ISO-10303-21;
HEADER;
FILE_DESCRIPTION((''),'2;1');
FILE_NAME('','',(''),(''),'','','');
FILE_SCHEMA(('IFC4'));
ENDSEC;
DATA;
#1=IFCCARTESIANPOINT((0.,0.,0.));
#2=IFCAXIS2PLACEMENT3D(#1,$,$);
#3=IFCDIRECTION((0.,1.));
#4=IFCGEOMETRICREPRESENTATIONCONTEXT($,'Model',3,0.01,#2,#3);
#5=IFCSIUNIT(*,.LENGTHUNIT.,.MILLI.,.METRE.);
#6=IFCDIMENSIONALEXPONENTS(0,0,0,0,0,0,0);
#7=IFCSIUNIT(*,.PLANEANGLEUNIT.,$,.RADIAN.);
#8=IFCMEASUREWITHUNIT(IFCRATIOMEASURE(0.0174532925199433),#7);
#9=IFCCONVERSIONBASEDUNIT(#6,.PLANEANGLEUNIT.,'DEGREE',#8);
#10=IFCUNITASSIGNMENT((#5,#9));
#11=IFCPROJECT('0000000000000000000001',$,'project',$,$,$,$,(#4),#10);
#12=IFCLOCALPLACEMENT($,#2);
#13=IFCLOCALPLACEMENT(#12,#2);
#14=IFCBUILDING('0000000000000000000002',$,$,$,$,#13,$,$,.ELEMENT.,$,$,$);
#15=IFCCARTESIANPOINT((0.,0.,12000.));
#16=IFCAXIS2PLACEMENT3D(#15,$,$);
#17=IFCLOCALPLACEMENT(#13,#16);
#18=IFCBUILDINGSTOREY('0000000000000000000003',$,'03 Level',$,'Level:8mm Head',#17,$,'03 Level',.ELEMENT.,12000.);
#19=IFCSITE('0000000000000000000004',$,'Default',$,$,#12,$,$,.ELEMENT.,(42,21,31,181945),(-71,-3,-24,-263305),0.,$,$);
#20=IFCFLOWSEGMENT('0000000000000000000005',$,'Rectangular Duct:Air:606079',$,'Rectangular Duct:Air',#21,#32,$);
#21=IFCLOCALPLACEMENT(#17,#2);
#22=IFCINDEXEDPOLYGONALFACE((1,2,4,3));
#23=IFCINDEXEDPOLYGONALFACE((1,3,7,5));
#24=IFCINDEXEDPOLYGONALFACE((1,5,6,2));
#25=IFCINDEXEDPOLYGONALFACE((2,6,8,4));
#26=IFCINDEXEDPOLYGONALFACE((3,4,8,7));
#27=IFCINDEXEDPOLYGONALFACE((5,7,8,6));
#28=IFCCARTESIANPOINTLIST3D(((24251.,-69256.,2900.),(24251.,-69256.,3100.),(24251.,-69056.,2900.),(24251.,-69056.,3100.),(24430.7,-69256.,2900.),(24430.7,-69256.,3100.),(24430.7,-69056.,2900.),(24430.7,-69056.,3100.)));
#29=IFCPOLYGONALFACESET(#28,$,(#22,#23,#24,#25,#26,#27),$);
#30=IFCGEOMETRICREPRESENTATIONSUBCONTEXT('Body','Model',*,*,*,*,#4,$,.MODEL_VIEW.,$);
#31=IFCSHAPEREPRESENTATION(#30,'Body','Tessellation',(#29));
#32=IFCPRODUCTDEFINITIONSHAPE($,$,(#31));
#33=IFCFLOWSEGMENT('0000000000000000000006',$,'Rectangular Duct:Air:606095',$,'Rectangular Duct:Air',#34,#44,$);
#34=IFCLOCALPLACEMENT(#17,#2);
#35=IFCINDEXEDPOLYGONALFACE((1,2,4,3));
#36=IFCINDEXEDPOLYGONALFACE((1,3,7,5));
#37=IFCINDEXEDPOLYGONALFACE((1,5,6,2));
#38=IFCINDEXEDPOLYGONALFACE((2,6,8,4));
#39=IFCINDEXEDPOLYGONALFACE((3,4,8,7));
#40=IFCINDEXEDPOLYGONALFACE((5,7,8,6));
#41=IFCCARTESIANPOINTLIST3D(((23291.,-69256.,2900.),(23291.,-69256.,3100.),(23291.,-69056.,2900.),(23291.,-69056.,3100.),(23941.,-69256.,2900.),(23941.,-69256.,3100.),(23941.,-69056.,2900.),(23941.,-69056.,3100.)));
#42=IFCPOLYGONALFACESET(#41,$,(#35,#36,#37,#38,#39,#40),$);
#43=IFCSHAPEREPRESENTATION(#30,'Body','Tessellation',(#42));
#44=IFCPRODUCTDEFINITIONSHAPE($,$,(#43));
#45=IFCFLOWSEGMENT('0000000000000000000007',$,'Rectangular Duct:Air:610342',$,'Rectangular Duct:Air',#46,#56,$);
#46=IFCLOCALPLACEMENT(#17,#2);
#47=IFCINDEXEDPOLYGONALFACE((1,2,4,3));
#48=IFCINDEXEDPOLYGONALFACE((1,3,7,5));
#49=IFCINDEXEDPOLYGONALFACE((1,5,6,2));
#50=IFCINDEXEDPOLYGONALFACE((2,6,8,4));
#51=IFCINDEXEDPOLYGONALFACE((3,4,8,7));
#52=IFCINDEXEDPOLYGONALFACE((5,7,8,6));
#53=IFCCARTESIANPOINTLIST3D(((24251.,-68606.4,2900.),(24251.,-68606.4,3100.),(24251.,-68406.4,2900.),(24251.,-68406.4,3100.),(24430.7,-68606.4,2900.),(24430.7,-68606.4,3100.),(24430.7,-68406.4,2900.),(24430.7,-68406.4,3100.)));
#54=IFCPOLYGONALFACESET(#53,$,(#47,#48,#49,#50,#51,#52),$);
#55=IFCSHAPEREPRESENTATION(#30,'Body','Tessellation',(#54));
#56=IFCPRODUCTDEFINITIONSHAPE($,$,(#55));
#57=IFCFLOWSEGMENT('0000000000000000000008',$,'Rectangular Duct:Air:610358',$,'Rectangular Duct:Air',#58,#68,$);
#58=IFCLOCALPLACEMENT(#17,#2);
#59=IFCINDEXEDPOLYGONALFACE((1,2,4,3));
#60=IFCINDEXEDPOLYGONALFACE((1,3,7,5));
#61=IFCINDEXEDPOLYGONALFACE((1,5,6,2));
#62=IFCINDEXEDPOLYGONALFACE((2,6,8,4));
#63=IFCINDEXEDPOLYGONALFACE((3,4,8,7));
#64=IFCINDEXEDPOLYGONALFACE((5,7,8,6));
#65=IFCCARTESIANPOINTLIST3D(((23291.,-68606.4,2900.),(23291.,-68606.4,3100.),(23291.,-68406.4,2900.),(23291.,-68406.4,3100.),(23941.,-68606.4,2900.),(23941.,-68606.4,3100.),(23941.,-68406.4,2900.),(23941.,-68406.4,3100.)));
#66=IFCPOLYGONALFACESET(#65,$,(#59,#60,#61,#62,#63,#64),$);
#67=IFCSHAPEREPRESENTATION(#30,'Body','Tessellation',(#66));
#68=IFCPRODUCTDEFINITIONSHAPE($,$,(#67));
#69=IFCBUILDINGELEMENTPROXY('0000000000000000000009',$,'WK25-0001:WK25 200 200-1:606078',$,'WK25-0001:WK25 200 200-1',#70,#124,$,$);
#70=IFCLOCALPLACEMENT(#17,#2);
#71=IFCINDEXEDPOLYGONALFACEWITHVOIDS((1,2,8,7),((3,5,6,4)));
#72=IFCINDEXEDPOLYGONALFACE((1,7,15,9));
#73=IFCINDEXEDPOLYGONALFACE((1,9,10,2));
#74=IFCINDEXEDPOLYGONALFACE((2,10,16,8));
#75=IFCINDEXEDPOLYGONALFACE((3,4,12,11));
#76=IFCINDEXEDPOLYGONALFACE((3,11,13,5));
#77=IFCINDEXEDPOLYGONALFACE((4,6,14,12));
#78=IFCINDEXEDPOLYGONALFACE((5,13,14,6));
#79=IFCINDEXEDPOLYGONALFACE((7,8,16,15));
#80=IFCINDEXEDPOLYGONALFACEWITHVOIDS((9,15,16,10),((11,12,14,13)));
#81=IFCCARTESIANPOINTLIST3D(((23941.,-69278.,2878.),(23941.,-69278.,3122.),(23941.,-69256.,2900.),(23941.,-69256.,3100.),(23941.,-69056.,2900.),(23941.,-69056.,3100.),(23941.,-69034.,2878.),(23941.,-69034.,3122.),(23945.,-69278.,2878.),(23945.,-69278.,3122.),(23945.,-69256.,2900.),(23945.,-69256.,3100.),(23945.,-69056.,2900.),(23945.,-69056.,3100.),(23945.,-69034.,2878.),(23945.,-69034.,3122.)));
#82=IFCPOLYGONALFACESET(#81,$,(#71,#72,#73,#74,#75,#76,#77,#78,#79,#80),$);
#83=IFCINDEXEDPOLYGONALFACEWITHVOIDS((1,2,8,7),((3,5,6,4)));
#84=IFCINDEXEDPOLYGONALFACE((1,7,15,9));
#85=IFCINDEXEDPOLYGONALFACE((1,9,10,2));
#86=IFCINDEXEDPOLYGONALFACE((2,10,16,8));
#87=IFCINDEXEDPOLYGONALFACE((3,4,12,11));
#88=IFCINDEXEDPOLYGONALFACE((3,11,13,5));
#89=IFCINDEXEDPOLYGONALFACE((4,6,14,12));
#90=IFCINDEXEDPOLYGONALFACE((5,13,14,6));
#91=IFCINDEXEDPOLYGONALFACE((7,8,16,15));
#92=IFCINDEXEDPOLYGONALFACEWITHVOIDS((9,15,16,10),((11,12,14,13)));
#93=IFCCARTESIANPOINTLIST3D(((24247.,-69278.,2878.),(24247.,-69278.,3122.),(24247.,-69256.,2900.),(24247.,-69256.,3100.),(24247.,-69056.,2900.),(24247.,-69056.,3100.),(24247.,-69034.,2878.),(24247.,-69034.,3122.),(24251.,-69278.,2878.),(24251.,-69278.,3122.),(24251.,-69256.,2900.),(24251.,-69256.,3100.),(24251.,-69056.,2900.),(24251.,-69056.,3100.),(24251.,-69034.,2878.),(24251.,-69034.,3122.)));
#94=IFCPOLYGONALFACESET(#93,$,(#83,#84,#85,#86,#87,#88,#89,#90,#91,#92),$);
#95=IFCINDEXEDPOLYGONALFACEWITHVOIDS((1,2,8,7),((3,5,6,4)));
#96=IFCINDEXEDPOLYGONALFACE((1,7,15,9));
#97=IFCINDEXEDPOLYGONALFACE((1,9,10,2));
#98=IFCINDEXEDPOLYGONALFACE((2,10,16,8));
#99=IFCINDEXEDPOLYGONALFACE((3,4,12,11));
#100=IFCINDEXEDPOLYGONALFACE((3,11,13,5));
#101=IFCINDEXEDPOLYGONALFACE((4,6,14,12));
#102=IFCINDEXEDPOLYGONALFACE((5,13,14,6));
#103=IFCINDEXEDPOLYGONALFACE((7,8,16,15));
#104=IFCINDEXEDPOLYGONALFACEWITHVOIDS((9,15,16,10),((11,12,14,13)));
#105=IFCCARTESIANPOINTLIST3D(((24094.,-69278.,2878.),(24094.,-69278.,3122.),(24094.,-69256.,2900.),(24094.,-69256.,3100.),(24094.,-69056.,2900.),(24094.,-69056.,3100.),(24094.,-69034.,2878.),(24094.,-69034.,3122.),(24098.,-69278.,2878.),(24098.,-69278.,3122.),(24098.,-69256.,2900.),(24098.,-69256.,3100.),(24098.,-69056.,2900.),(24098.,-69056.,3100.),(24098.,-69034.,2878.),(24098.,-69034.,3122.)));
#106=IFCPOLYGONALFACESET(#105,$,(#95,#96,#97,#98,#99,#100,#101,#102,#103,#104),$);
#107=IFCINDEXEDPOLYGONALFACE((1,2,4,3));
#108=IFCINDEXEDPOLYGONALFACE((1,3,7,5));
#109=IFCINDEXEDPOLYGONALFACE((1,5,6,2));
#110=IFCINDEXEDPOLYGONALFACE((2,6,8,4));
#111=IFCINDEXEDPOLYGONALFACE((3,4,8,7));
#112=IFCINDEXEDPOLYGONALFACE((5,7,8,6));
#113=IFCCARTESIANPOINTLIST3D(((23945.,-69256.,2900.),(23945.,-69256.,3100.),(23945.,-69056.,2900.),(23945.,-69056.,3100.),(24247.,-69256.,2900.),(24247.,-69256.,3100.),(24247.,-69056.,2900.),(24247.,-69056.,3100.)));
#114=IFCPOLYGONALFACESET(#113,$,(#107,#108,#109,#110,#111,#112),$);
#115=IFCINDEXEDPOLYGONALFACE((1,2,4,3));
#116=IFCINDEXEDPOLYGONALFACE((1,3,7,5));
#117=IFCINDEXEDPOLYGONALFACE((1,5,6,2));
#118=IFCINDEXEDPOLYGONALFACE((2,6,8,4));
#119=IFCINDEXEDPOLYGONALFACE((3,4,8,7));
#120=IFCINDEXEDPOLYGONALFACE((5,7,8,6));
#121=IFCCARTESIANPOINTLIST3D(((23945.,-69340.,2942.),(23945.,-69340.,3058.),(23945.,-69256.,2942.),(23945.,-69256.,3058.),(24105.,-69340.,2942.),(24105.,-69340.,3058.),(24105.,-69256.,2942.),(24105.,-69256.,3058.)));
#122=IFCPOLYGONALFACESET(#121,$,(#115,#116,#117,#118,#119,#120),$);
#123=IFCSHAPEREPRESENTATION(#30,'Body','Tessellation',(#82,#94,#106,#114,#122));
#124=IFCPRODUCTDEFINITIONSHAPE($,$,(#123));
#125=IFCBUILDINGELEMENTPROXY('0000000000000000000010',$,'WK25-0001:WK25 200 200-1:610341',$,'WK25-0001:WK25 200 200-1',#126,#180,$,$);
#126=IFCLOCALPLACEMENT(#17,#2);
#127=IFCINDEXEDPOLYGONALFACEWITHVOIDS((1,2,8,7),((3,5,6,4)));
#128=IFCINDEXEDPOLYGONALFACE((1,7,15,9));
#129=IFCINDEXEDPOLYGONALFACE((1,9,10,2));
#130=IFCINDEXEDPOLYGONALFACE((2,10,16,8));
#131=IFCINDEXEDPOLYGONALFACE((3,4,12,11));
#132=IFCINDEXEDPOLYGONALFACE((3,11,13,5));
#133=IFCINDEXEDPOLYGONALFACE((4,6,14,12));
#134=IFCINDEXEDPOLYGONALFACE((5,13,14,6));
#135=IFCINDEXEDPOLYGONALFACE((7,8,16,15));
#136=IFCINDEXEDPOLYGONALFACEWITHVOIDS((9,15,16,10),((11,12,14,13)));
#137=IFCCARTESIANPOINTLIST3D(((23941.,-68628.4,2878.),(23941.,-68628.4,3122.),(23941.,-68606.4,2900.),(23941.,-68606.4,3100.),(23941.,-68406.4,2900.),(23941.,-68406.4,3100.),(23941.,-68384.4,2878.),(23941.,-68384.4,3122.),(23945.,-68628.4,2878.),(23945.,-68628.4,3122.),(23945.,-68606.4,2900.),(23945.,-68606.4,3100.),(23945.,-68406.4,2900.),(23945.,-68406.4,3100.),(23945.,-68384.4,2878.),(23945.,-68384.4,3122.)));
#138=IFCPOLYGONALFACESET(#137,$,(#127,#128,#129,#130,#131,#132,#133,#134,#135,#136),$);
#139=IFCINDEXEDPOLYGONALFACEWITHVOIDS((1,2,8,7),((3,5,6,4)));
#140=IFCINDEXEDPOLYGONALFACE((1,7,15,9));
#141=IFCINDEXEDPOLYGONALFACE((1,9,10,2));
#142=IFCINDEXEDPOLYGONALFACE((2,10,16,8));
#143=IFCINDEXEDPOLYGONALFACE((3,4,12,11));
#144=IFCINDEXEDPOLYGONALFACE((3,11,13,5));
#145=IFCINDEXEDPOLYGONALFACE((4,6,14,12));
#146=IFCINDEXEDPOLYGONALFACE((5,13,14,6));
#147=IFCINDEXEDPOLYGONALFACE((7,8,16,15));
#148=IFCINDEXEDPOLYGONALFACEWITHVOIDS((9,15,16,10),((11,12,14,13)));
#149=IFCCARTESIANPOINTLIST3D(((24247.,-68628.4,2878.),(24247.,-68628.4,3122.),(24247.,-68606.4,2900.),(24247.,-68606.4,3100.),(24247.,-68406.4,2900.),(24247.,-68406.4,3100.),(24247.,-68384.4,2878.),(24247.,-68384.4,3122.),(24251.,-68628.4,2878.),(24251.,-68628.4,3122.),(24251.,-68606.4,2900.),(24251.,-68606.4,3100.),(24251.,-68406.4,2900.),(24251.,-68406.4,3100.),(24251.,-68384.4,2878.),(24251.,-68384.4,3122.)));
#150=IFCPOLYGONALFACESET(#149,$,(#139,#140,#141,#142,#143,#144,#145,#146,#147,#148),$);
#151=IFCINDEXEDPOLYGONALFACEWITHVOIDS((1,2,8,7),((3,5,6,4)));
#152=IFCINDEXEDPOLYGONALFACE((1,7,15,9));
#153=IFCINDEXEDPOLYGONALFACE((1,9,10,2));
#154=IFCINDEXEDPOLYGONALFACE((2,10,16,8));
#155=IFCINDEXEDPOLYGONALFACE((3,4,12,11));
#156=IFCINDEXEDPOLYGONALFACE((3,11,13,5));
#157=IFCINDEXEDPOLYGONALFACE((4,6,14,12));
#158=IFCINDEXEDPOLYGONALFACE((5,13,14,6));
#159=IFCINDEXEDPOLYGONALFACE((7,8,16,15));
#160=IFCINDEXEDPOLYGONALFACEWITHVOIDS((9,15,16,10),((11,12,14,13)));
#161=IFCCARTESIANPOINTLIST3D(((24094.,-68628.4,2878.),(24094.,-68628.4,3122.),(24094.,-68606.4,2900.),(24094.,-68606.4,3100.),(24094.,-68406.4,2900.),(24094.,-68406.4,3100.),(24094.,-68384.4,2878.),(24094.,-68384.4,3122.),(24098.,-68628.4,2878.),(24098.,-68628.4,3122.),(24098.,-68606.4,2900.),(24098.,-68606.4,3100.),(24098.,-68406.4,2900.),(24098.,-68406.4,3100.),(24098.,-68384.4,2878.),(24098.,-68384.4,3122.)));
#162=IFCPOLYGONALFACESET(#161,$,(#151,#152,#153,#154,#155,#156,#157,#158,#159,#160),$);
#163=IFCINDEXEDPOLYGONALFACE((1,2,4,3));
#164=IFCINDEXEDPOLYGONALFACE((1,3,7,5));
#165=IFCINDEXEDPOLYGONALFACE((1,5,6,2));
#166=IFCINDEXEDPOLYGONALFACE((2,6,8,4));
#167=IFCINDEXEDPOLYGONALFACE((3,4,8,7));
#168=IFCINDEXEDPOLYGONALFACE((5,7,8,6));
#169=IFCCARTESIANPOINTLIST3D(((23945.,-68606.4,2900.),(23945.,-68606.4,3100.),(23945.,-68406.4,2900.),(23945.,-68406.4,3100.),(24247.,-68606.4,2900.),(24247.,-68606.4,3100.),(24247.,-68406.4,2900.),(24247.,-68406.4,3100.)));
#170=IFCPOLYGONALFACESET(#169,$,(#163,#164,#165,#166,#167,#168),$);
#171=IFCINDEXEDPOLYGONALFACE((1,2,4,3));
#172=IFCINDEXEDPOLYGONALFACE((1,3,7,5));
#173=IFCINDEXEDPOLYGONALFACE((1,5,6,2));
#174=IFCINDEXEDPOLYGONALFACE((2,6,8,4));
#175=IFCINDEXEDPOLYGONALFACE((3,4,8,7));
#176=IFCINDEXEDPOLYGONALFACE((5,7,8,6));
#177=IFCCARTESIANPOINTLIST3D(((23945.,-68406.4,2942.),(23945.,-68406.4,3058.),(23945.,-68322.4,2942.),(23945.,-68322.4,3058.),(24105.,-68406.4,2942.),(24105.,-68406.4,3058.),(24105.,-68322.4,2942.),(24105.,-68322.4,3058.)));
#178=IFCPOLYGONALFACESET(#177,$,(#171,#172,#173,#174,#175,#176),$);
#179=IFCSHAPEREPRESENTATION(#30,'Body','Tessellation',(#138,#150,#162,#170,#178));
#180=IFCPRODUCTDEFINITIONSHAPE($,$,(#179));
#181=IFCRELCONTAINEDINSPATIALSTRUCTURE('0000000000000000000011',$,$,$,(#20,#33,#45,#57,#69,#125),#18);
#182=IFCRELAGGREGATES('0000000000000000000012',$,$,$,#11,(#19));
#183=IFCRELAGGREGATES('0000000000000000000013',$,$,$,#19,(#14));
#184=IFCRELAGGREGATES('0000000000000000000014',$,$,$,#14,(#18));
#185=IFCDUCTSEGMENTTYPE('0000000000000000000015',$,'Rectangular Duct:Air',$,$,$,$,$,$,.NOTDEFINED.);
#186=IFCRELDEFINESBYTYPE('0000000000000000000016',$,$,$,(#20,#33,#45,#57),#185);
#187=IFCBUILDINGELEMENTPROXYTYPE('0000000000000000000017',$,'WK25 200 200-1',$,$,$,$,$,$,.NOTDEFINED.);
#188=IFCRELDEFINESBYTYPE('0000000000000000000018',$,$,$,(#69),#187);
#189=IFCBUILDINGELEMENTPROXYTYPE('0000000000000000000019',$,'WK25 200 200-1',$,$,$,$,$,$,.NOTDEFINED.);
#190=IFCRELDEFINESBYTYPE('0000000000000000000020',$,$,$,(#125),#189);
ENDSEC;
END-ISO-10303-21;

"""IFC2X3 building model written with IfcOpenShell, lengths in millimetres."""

from ifc_helpers import new_model, entity, si_unit, converted_unit, direction, frame, frame_2d, origin, origin_2d_with_axis, place, context, subcontext, project, spatial, polyline, rectangle, outline, extrude, source, transform, mapped, type_object, type_shapes, element, save


model = new_model("IFC2X3")

# Units and contexts
model_context = context("Model", 3, precision=0.01, world=origin(), true_north=direction((0.0, 1.0)))
body_context = subcontext(model_context, "Body", "Model", "MODEL_VIEW")
ifc_project = project(units=[si_unit("LENGTHUNIT", "METRE", prefix="MILLI"), converted_unit("PLANEANGLEUNIT", "DEGREE", entity("IfcRatioMeasure", 0.0174532925199433), si_unit("PLANEANGLEUNIT", "RADIAN"), dimensions=[0, 0, 0, 0, 0, 0, 0])], contexts=[model_context])

# Site, building, storey
site_placement = place(None, origin())
site = spatial("IfcSite", under=ifc_project, at=site_placement, Name="Default", CompositionType="ELEMENT", RefLatitude=(42, 21, 31, 181945), RefLongitude=(-71, -3, -24, -263305), RefElevation=0.0)
building_placement = place(site_placement, origin())
building = spatial("IfcBuilding", under=site, at=building_placement, CompositionType="ELEMENT")
storey_placement = place(building_placement, frame((0.0, 0.0, 12000.0)))
storey = spatial("IfcBuildingStorey", under=building, at=storey_placement, Name="03 Level", ObjectType="Level:8mm Head", LongName="03 Level", CompositionType="ELEMENT", Elevation=12000.0)

# Flow segments
duct_segment_type_1 = type_object("IfcDuctSegmentType", Name="Rectangular Duct:Air", PredefinedType="NOTDEFINED")
flow_segment_1_placement = place(storey_placement, frame((24251.0, -69256.0, 2900.0)))
element("IfcFlowSegment", 1, at=flow_segment_1_placement, inside=storey, type_object=duct_segment_type_1, Name="Rectangular Duct:Air:606079", ObjectType="Rectangular Duct:Air", context=body_context, shape_type="SweptSolid", body=[
    extrude(rectangle(XDim=179.7, YDim=200.0, at=frame_2d((0.0, 0.0), x_axis=(1.0, 0.0))), frame((89.8, 100.0, 0.0)), (0.0, 0.0, 1.0), 200.0),
])
flow_segment_2_placement = place(storey_placement, frame((23291.0, -69256.0, 2900.0)))
element("IfcFlowSegment", 2, at=flow_segment_2_placement, inside=storey, type_object=duct_segment_type_1, Name="Rectangular Duct:Air:606095", ObjectType="Rectangular Duct:Air", context=body_context, shape_type="SweptSolid", body=[
    extrude(rectangle(XDim=650.0, YDim=200.0, at=frame_2d((0.0, 0.0), x_axis=(1.0, 0.0))), frame((325.0, 100.0, 0.0), z_axis=(0.0, 0.0, 1.0), x_axis=(-1.0, 0.0, 0.0)), (0.0, 0.0, 1.0), 200.0),
])
flow_segment_3_placement = place(storey_placement, frame((24251.0, -68606.4, 2900.0)))
element("IfcFlowSegment", 3, at=flow_segment_3_placement, inside=storey, type_object=duct_segment_type_1, Name="Rectangular Duct:Air:610342", ObjectType="Rectangular Duct:Air", context=body_context, shape_type="SweptSolid", body=[
    extrude(rectangle(XDim=179.7, YDim=200.0, at=frame_2d((0.0, 0.0), x_axis=(1.0, 0.0))), frame((89.8, 100.0, 0.0)), (0.0, 0.0, 1.0), 200.0),
])
flow_segment_4_placement = place(storey_placement, frame((23291.0, -68606.4, 2900.0)))
element("IfcFlowSegment", 4, at=flow_segment_4_placement, inside=storey, type_object=duct_segment_type_1, Name="Rectangular Duct:Air:610358", ObjectType="Rectangular Duct:Air", context=body_context, shape_type="SweptSolid", body=[
    extrude(rectangle(XDim=650.0, YDim=200.0, at=frame_2d((0.0, 0.0), x_axis=(1.0, 0.0))), frame((325.0, 100.0, 0.0), z_axis=(0.0, 0.0, 1.0), x_axis=(-1.0, 0.0, 0.0)), (0.0, 0.0, 1.0), 200.0),
])

# Building element proxies
building_element_proxy_type_1 = type_object("IfcBuildingElementProxyType", Name="WK25 200 200-1", PredefinedType="NOTDEFINED")
shared_shape_1 = source(origin(), body_context, "Body", "SweptSolid", [
    extrude(outline(polyline([(-122.0, -122.0), (122.0, -122.0), (122.0, 122.0), (-122.0, 122.0), (-122.0, -122.0)]), holes=[polyline([(-100.0, -100.0), (-100.0, 100.0), (100.0, 100.0), (100.0, -100.0), (-100.0, -100.0)])]), frame((151.0, 0.0, 0.0), z_axis=(1.0, 0.0, 0.0), x_axis=(0.0, 0.0, -1.0)), (0.0, 0.0, 1.0), 4.0),
    extrude(outline(polyline([(-122.0, -122.0), (122.0, -122.0), (122.0, 122.0), (-122.0, 122.0), (-122.0, -122.0)]), holes=[polyline([(-100.0, -100.0), (-100.0, 100.0), (100.0, 100.0), (100.0, -100.0), (-100.0, -100.0)])]), frame((-155.0, 0.0, 0.0), z_axis=(1.0, 0.0, 0.0), x_axis=(0.0, -1.0, 0.0)), (0.0, 0.0, 1.0), 4.0),
    extrude(outline(polyline([(-122.0, -122.0), (122.0, -122.0), (122.0, 122.0), (-122.0, 122.0), (-122.0, -122.0)]), holes=[polyline([(-100.0, -100.0), (-100.0, 100.0), (100.0, 100.0), (100.0, -100.0), (-100.0, -100.0)])]), frame((-2.0, 0.0, 0.0), z_axis=(1.0, 0.0, 0.0), x_axis=(0.0, -1.0, 0.0)), (0.0, 0.0, 1.0), 4.0),
    extrude(rectangle(XDim=302.0, YDim=200.0, at=origin_2d_with_axis()), frame((0.0, 0.0, -100.0), z_axis=(0.0, 0.0, 1.0), x_axis=(-1.0, 0.0, 0.0)), (0.0, 0.0, 1.0), 200.0),
    extrude(rectangle(XDim=84.0, YDim=160.0, at=frame_2d((0.0, 0.0), x_axis=(1.0, 0.0))), frame((71.0, -142.0, -58.0), z_axis=(0.0, 0.0, 1.0), x_axis=(0.0, -1.0, 0.0)), (0.0, 0.0, 1.0), 116.0),
])
type_shapes(building_element_proxy_type_1, [shared_shape_1])
proxy_1_placement = place(storey_placement, frame((24096.0, -69156.0, 3000.0), z_axis=(0.0, 0.0, -1.0), x_axis=(-1.0, 0.0, 0.0)))
element("IfcBuildingElementProxy", 5, at=proxy_1_placement, inside=storey, type_object=building_element_proxy_type_1, Name="WK25-0001:WK25 200 200-1:606078", ObjectType="WK25-0001:WK25 200 200-1", context=body_context, shape_type="MappedRepresentation", body=[
    mapped(shared_shape_1, transform((0.0, 0.0, 0.0), scale=1.0)),
])
building_element_proxy_type_2 = type_object("IfcBuildingElementProxyType", Name="WK25 200 200-1", PredefinedType="NOTDEFINED")
shared_shape_2 = source(origin(), body_context, "Body", "SweptSolid", [
    extrude(outline(polyline([(-122.0, -122.0), (122.0, -122.0), (122.0, 122.0), (-122.0, 122.0), (-122.0, -122.0)]), holes=[polyline([(-100.0, -100.0), (-100.0, 100.0), (100.0, 100.0), (100.0, -100.0), (-100.0, -100.0)])]), frame((151.0, 0.0, 0.0), z_axis=(1.0, 0.0, 0.0), x_axis=(0.0, -1.0, 0.0)), (0.0, 0.0, 1.0), 4.0),
    extrude(outline(polyline([(-122.0, -122.0), (122.0, -122.0), (122.0, 122.0), (-122.0, 122.0), (-122.0, -122.0)]), holes=[polyline([(-100.0, -100.0), (-100.0, 100.0), (100.0, 100.0), (100.0, -100.0), (-100.0, -100.0)])]), frame((-155.0, 0.0, 0.0), z_axis=(1.0, 0.0, 0.0), x_axis=(0.0, 0.0, -1.0)), (0.0, 0.0, 1.0), 4.0),
    extrude(outline(polyline([(-122.0, -122.0), (122.0, -122.0), (122.0, 122.0), (-122.0, 122.0), (-122.0, -122.0)]), holes=[polyline([(-100.0, -100.0), (-100.0, 100.0), (100.0, 100.0), (100.0, -100.0), (-100.0, -100.0)])]), frame((-2.0, 0.0, 0.0), z_axis=(1.0, 0.0, 0.0), x_axis=(0.0, 0.0, -1.0)), (0.0, 0.0, 1.0), 4.0),
    extrude(rectangle(XDim=200.0, YDim=302.0, at=origin_2d_with_axis()), frame((0.0, 0.0, -100.0), z_axis=(0.0, 0.0, 1.0), x_axis=(0.0, 1.0, 0.0)), (0.0, 0.0, 1.0), 200.0),
    extrude(rectangle(XDim=160.0, YDim=84.0, at=frame_2d((0.0, 0.0), x_axis=(1.0, 0.0))), frame((71.0, 142.0, -58.0)), (0.0, 0.0, 1.0), 116.0),
])
type_shapes(building_element_proxy_type_2, [shared_shape_2])
proxy_2_placement = place(storey_placement, frame((24096.0, -68506.4, 3000.0), z_axis=(0.0, 0.0, -1.0), x_axis=(-1.0, 0.0, 0.0)))
element("IfcBuildingElementProxy", 6, at=proxy_2_placement, inside=storey, type_object=building_element_proxy_type_2, Name="WK25-0001:WK25 200 200-1:610341", ObjectType="WK25-0001:WK25 200 200-1", context=body_context, shape_type="MappedRepresentation", body=[
    mapped(shared_shape_2, transform((0.0, 0.0, 0.0), scale=1.0)),
])

save(model, "model.ifc")
